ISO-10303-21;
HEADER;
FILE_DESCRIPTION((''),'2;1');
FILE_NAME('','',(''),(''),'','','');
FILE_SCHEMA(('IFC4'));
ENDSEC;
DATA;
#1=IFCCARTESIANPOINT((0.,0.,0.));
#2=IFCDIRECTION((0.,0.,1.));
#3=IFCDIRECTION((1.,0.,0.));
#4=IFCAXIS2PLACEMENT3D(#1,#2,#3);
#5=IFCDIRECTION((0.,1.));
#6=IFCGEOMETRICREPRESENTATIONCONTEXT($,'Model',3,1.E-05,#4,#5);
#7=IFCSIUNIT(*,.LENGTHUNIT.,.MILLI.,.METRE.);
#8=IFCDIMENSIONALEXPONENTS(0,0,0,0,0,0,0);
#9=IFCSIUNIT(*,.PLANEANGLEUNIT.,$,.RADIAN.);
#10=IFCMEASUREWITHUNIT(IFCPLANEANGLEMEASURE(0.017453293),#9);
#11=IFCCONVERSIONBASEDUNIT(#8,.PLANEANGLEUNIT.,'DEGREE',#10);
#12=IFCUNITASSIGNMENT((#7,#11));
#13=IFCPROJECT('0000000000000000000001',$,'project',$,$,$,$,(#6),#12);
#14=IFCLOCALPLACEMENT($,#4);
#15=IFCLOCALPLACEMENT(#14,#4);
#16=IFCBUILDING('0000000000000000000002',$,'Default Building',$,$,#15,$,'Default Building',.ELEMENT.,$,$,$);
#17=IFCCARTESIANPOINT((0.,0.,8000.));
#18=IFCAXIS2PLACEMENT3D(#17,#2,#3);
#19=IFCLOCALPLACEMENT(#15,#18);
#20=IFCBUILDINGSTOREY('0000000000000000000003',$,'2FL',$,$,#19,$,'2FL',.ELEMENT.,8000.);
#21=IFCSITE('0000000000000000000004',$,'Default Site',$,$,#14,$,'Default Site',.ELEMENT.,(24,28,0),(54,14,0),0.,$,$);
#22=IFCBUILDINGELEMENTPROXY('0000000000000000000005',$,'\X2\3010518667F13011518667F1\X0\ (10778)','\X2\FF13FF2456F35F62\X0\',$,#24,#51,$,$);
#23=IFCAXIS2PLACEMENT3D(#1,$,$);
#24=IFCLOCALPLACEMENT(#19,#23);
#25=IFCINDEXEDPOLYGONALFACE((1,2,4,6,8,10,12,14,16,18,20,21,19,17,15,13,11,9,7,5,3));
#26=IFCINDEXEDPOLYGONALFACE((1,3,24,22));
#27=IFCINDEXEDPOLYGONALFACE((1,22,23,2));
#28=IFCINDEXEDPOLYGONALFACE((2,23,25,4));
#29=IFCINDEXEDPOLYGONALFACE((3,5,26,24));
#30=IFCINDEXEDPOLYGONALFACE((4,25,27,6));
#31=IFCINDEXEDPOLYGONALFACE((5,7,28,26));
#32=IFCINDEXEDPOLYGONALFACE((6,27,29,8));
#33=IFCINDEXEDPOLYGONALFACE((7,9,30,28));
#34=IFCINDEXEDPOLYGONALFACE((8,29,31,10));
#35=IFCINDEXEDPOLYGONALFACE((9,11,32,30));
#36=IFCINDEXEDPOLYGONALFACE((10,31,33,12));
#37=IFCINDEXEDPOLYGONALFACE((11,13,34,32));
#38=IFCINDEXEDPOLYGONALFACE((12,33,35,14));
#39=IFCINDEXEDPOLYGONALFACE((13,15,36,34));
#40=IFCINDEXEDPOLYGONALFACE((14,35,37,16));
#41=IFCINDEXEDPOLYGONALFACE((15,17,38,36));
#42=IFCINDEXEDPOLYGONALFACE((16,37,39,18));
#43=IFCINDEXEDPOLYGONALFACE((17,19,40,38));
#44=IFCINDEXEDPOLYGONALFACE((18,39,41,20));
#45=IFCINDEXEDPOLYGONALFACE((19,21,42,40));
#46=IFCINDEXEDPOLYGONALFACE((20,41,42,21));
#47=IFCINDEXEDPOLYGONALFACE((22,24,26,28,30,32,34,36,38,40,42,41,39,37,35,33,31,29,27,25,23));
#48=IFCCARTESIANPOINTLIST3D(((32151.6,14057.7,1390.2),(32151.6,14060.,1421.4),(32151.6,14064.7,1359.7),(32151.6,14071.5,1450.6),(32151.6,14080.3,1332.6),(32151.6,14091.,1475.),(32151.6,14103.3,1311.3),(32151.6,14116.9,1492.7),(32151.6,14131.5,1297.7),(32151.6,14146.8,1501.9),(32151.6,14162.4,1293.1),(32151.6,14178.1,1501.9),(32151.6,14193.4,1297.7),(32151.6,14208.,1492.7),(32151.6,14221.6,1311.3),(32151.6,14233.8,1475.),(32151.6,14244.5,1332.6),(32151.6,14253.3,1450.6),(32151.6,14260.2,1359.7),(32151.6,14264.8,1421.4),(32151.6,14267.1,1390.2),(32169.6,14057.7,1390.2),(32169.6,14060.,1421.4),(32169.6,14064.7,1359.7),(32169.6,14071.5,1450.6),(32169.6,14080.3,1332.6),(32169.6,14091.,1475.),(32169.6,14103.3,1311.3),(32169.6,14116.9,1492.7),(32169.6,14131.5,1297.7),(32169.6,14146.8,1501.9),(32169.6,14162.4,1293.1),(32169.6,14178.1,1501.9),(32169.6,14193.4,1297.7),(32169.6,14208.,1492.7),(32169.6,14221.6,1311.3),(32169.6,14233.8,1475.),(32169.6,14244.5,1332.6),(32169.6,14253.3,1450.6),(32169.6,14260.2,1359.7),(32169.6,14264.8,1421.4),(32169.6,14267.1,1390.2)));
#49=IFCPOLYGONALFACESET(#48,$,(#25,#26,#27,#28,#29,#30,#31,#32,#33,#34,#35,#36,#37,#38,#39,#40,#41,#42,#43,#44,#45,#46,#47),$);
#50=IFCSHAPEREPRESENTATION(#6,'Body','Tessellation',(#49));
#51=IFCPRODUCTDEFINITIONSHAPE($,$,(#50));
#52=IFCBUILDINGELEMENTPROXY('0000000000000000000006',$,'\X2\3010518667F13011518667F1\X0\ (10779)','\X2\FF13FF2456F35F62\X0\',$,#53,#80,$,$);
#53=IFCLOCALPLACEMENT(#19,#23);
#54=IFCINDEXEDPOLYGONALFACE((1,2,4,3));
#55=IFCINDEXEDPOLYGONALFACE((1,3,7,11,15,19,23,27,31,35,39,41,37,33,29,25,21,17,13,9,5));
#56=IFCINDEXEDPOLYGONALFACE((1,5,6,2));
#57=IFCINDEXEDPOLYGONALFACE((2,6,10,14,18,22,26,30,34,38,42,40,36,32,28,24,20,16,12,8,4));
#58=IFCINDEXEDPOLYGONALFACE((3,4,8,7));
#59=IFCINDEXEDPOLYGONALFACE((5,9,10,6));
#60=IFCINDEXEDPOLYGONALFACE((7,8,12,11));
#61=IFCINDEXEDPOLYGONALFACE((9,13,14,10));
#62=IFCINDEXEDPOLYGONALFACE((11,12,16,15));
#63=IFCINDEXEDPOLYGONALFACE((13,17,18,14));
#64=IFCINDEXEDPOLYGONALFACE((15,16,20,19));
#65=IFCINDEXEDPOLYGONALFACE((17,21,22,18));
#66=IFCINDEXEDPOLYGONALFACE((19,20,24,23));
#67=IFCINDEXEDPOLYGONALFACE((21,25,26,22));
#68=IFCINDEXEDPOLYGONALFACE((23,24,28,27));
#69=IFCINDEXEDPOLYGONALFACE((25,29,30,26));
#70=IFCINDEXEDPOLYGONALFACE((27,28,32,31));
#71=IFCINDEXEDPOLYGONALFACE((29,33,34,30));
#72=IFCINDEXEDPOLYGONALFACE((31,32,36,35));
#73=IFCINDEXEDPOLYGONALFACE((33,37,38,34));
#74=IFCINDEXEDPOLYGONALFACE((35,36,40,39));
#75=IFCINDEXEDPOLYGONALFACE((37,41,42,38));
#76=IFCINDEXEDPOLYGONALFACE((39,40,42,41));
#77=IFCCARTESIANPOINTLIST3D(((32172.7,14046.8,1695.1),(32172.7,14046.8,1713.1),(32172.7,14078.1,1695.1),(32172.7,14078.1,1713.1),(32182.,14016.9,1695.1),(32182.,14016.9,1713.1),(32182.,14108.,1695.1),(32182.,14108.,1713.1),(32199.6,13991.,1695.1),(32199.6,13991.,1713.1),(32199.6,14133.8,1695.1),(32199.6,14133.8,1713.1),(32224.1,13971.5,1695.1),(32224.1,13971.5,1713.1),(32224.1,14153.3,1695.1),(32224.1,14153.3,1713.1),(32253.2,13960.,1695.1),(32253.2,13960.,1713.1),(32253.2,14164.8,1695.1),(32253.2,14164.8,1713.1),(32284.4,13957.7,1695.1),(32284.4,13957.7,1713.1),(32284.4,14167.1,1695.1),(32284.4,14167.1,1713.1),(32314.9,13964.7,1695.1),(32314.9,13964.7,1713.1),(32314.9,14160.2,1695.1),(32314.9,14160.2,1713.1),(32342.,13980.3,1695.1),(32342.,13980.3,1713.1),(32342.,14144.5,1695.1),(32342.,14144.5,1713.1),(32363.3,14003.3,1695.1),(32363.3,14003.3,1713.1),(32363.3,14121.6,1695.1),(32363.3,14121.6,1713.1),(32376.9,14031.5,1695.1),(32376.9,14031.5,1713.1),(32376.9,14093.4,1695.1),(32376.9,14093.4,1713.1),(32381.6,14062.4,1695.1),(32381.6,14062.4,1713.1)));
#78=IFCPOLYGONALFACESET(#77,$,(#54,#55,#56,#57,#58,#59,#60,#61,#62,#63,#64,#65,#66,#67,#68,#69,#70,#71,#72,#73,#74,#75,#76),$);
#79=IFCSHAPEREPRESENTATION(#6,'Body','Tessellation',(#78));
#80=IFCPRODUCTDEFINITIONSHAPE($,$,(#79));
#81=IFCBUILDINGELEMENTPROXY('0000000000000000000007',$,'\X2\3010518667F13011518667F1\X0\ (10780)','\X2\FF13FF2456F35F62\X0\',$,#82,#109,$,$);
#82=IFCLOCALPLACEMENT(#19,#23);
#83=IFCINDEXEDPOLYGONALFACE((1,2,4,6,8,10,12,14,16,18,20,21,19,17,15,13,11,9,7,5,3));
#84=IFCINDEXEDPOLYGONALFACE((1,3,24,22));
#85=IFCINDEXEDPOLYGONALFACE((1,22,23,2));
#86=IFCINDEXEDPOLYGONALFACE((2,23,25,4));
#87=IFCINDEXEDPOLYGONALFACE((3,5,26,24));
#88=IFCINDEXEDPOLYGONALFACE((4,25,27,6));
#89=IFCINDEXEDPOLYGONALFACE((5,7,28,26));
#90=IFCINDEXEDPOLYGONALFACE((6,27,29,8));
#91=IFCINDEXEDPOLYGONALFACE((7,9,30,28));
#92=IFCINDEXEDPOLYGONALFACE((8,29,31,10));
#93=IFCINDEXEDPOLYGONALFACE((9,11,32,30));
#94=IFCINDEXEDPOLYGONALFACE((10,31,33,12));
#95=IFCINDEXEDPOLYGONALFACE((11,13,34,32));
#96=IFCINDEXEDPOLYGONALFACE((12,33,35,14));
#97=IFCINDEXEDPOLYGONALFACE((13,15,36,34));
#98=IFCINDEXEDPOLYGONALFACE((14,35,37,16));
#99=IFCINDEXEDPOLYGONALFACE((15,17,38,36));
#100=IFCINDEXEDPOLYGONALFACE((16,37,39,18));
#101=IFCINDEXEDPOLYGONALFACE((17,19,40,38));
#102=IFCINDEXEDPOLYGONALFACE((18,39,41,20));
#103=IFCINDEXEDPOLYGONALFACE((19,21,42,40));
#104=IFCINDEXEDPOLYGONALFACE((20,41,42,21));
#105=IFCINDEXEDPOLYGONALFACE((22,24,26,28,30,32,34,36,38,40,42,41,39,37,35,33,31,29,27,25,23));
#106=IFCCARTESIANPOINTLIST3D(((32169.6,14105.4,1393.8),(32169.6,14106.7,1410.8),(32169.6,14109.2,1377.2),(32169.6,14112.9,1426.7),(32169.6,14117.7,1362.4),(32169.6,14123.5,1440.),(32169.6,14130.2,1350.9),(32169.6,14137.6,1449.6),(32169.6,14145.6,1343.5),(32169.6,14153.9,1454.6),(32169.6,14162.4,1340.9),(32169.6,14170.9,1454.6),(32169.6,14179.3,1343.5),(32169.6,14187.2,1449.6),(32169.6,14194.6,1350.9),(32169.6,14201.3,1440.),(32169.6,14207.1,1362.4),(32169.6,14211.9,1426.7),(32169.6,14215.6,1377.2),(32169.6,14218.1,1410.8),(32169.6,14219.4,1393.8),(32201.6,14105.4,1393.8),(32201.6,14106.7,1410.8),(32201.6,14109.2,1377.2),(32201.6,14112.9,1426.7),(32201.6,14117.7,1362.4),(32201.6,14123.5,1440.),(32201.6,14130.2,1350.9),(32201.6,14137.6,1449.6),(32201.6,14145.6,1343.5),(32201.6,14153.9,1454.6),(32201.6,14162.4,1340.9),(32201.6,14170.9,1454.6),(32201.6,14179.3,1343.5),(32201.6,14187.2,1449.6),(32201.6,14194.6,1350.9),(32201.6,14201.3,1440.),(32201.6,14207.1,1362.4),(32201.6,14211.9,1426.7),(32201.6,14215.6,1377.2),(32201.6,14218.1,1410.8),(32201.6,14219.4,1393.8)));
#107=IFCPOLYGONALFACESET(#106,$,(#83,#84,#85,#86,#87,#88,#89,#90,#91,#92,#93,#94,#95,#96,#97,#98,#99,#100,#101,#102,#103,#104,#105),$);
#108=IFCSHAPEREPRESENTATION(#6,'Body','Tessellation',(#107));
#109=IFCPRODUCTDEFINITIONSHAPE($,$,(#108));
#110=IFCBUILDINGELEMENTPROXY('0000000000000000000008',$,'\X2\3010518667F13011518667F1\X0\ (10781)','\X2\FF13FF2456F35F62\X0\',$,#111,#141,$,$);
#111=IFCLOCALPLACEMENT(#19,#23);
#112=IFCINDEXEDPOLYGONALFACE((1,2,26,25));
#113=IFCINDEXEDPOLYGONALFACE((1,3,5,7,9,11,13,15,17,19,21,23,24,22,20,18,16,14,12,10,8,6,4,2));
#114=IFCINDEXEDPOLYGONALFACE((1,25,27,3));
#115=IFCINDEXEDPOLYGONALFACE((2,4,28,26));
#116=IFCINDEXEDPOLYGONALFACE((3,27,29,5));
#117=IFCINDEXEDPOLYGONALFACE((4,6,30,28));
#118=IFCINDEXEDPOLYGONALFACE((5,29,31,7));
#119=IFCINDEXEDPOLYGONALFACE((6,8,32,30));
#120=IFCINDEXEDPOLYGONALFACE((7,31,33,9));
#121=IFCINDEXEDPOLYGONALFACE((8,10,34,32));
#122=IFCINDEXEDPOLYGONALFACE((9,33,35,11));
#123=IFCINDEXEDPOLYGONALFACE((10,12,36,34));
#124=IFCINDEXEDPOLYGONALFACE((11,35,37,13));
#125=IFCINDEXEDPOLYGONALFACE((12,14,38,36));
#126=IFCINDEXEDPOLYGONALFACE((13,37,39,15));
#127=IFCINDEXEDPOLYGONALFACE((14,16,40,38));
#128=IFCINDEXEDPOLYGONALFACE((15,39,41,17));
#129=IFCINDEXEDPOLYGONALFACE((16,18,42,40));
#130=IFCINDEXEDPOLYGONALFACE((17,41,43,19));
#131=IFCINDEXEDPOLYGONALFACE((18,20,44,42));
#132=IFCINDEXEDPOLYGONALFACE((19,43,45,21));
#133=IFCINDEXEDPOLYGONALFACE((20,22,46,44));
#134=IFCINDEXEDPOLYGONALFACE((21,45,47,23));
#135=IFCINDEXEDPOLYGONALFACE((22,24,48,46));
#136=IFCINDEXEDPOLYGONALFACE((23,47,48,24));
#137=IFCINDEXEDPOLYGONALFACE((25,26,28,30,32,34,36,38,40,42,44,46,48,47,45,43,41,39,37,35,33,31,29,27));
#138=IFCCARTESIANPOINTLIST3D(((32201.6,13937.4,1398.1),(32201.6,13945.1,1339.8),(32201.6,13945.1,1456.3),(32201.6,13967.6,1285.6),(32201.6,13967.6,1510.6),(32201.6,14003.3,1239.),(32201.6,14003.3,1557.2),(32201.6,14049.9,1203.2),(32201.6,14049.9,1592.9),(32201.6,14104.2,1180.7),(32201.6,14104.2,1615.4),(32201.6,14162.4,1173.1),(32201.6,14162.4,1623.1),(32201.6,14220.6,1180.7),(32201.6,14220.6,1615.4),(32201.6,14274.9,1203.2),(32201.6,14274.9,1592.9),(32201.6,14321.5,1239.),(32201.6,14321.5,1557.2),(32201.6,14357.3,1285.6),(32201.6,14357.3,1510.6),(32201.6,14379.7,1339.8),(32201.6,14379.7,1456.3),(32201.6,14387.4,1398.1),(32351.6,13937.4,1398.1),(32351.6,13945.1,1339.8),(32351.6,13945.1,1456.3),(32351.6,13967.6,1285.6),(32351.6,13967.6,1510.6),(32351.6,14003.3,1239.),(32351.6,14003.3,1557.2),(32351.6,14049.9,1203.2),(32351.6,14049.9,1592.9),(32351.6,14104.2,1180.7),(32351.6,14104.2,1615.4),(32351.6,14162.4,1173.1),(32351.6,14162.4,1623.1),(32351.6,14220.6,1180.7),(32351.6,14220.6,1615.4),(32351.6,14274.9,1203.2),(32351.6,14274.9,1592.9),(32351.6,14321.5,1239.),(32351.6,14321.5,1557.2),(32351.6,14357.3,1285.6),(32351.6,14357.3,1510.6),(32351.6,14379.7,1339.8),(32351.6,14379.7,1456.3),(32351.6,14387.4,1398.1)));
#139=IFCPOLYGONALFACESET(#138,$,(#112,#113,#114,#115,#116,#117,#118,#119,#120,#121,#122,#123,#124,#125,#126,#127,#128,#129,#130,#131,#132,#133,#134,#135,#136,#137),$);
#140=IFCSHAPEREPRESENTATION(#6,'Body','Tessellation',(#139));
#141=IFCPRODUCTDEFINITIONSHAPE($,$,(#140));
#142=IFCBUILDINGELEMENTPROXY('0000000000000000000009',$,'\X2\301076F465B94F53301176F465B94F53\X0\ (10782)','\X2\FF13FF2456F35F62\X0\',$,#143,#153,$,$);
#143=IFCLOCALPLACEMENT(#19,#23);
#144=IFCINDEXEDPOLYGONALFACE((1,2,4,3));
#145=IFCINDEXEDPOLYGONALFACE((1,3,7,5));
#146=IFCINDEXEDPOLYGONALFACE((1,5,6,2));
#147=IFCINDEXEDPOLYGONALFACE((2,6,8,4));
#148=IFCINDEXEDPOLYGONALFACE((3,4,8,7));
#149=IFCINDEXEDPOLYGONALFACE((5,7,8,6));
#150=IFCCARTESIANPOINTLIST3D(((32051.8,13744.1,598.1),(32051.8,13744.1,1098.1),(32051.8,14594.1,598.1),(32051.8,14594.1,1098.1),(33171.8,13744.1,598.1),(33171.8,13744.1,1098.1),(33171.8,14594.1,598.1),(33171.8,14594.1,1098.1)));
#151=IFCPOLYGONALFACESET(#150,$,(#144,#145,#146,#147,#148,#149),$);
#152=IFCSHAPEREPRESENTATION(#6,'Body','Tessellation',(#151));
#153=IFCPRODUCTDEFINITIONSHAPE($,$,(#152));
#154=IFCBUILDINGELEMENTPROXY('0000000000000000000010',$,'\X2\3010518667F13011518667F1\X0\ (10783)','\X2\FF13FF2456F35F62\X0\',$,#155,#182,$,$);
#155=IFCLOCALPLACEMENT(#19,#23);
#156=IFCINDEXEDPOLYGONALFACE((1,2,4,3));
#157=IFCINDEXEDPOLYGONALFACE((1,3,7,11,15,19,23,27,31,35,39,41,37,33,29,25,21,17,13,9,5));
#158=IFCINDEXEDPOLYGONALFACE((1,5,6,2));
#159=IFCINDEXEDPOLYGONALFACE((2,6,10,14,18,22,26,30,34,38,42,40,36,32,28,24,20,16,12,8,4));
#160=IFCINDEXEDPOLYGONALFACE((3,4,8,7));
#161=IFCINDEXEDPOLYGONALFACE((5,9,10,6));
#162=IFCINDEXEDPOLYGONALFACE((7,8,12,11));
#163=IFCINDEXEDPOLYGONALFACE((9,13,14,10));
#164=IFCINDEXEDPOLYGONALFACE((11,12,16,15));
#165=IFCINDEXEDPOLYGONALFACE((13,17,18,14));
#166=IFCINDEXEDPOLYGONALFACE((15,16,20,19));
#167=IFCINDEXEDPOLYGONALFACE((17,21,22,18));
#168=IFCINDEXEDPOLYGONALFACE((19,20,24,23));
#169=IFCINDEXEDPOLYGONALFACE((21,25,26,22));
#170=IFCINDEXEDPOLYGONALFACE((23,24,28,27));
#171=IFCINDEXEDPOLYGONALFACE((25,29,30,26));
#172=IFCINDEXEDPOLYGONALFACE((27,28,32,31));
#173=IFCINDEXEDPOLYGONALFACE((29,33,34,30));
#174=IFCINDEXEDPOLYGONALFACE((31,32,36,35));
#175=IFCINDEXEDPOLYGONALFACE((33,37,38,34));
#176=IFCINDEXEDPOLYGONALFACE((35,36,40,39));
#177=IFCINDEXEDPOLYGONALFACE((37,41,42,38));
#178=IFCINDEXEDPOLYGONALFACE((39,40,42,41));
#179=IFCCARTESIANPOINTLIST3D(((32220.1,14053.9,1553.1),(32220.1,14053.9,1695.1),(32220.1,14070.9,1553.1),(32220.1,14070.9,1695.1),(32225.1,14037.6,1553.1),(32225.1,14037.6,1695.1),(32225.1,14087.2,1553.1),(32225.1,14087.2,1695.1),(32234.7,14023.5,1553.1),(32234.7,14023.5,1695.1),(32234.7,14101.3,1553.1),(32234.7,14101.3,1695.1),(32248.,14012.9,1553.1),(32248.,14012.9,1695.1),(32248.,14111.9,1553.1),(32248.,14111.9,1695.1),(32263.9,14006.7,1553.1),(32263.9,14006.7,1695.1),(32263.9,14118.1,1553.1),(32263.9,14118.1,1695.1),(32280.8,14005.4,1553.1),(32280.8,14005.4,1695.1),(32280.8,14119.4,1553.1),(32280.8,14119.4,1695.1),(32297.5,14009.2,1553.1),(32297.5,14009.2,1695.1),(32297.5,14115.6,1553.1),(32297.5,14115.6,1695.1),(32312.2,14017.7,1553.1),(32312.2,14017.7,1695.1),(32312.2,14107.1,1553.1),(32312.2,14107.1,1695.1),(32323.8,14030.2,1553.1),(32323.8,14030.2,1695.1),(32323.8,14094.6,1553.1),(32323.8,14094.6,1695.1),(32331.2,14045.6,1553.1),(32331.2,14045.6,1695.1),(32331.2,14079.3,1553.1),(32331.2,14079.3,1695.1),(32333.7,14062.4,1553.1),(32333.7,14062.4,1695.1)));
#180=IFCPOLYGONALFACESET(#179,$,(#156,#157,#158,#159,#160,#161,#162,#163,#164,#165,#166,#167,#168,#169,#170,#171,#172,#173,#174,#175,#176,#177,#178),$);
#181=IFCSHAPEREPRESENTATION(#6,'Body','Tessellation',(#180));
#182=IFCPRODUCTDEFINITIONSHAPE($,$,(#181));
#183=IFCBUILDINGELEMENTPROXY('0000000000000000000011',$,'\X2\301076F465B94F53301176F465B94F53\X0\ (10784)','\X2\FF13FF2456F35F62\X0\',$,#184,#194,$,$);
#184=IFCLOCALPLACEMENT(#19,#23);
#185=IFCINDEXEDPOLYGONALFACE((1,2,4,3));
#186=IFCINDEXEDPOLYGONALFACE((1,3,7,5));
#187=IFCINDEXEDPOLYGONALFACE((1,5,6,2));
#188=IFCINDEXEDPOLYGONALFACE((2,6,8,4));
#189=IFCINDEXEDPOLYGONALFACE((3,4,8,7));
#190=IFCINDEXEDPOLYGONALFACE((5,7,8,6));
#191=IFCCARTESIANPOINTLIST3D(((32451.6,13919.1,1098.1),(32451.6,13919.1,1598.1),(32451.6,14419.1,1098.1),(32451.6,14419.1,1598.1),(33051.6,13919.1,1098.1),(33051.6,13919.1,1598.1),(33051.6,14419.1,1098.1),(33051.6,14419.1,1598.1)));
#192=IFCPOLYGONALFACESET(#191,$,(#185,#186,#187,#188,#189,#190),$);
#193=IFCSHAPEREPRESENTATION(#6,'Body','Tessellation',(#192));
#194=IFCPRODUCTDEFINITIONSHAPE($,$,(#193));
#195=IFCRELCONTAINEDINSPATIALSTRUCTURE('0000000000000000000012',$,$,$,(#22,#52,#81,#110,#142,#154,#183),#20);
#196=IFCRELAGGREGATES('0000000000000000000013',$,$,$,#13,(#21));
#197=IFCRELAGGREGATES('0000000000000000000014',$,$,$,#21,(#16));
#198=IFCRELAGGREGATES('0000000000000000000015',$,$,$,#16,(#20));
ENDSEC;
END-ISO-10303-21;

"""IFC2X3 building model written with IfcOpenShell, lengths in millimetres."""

from ifc_helpers import new_model, entity, si_unit, converted_unit, direction, frame, origin_with_axes, origin_2d_with_axis, place, context, project, spatial, rectangle, circle, extrude, source, transform, mapped, element, save


model = new_model("IFC2X3")

# Units and contexts
model_context = context("Model", 3, precision=1e-05, world=origin_with_axes(), true_north=direction((0.0, 1.0)))
ifc_project = project(units=[si_unit("LENGTHUNIT", "METRE", prefix="MILLI"), converted_unit("PLANEANGLEUNIT", "DEGREE", entity("IfcPlaneAngleMeasure", 0.017453293), si_unit("PLANEANGLEUNIT", "RADIAN"), dimensions=[0, 0, 0, 0, 0, 0, 0])], contexts=[model_context])

# Site, building, storey
site_placement = place(None, origin_with_axes())
site = spatial("IfcSite", under=ifc_project, at=site_placement, Name="Default Site", LongName="Default Site", CompositionType="ELEMENT", RefLatitude=(24, 28, 0), RefLongitude=(54, 14, 0), RefElevation=0.0)
building_placement = place(site_placement, origin_with_axes())
building = spatial("IfcBuilding", under=site, at=building_placement, Name="Default Building", LongName="Default Building", CompositionType="ELEMENT")
storey_placement = place(building_placement, frame((0.0, 0.0, 8000.0), z_axis=(0.0, 0.0, 1.0), x_axis=(1.0, 0.0, 0.0)))
storey = spatial("IfcBuildingStorey", under=building, at=storey_placement, Name="2FL", LongName="2FL", CompositionType="ELEMENT", Elevation=8000.0)

# Building element proxies
shared_shape_1 = source(origin_with_axes(), model_context, "Body", "SweptSolid", [
    extrude(circle(Radius=105.0, at=origin_2d_with_axis()), frame((0.0, 0.0, 0.0), z_axis=(0.0, 0.0, 1.0), x_axis=(1.0, 0.0, 0.0)), (0.0, 0.0, 1.0), 18.0),
])
proxy_1_placement = place(storey_placement, frame((32151.6, 14162.4, 1398.1), z_axis=(1.0, 0.0, 0.0), x_axis=(0.0, 0.0, -1.0)))
element("IfcBuildingElementProxy", 1, at=proxy_1_placement, inside=storey, Name="【円柱】円柱 (10778)", Description="３Ｄ図形", context=model_context, shape_type="MappedRepresentation", body=[
    mapped(shared_shape_1, transform((0.0, 0.0, 0.0))),
])
shared_shape_2 = source(origin_with_axes(), model_context, "Body", "SweptSolid", [
    extrude(circle(Radius=105.0, at=origin_2d_with_axis()), frame((0.0, 0.0, 0.0), z_axis=(0.0, 0.0, 1.0), x_axis=(1.0, 0.0, 0.0)), (0.0, 0.0, 1.0), 18.0),
])
proxy_2_placement = place(storey_placement, frame((32276.6, 14062.4, 1713.1), z_axis=(0.0, 0.0, -1.0), x_axis=(1.0, 0.0, 0.0)))
element("IfcBuildingElementProxy", 2, at=proxy_2_placement, inside=storey, Name="【円柱】円柱 (10779)", Description="３Ｄ図形", context=model_context, shape_type="MappedRepresentation", body=[
    mapped(shared_shape_2, transform((0.0, 0.0, 0.0))),
])
shared_shape_3 = source(origin_with_axes(), model_context, "Body", "SweptSolid", [
    extrude(circle(Radius=57.1, at=origin_2d_with_axis()), frame((0.0, 0.0, 0.0), z_axis=(0.0, 0.0, 1.0), x_axis=(1.0, 0.0, 0.0)), (0.0, 0.0, 1.0), 32.0),
])
proxy_3_placement = place(storey_placement, frame((32201.6, 14162.4, 1398.1), z_axis=(-1.0, 0.0, 0.0), x_axis=(0.0, 0.0, -1.0)))
element("IfcBuildingElementProxy", 3, at=proxy_3_placement, inside=storey, Name="【円柱】円柱 (10780)", Description="３Ｄ図形", context=model_context, shape_type="MappedRepresentation", body=[
    mapped(shared_shape_3, transform((0.0, 0.0, 0.0))),
])
shared_shape_4 = source(origin_with_axes(), model_context, "Body", "SweptSolid", [
    extrude(circle(Radius=225.0, at=origin_2d_with_axis()), frame((0.0, 0.0, 0.0), z_axis=(0.0, 0.0, 1.0), x_axis=(1.0, 0.0, 0.0)), (0.0, 0.0, 1.0), 150.0),
])
proxy_4_placement = place(storey_placement, frame((32351.6, 14162.4, 1398.1), z_axis=(-1.0, 0.0, 0.0), x_axis=(0.0, -1.0, 0.0)))
element("IfcBuildingElementProxy", 4, at=proxy_4_placement, inside=storey, Name="【円柱】円柱 (10781)", Description="３Ｄ図形", context=model_context, shape_type="MappedRepresentation", body=[
    mapped(shared_shape_4, transform((0.0, 0.0, 0.0))),
])
shared_shape_5 = source(origin_with_axes(), model_context, "Body", "SweptSolid", [
    extrude(rectangle(XDim=1120.0, YDim=850.0, at=origin_2d_with_axis()), origin_with_axes(), (0.0, 0.0, 1.0), 500.0),
])
proxy_5_placement = place(storey_placement, frame((32611.8, 14169.1, 598.1), z_axis=(0.0, 0.0, 1.0), x_axis=(1.0, 0.0, 0.0)))
element("IfcBuildingElementProxy", 5, at=proxy_5_placement, inside=storey, Name="【直方体】直方体 (10782)", Description="３Ｄ図形", context=model_context, shape_type="MappedRepresentation", body=[
    mapped(shared_shape_5, transform((0.0, 0.0, 0.0))),
])
shared_shape_6 = source(origin_with_axes(), model_context, "Body", "SweptSolid", [
    extrude(circle(Radius=57.1, at=origin_2d_with_axis()), origin_with_axes(), (0.0, 0.0, 1.0), 142.0),
])
proxy_6_placement = place(storey_placement, frame((32276.6, 14062.4, 1553.1), z_axis=(0.0, 0.0, 1.0), x_axis=(1.0, 0.0, 0.0)))
element("IfcBuildingElementProxy", 6, at=proxy_6_placement, inside=storey, Name="【円柱】円柱 (10783)", Description="３Ｄ図形", context=model_context, shape_type="MappedRepresentation", body=[
    mapped(shared_shape_6, transform((0.0, 0.0, 0.0))),
])
shared_shape_7 = source(origin_with_axes(), model_context, "Body", "SweptSolid", [
    extrude(rectangle(XDim=600.0, YDim=500.0, at=origin_2d_with_axis()), origin_with_axes(), (0.0, 0.0, 1.0), 500.0),
])
proxy_7_placement = place(storey_placement, frame((32751.6, 14169.1, 1098.1), z_axis=(0.0, 0.0, 1.0), x_axis=(1.0, 0.0, 0.0)))
element("IfcBuildingElementProxy", 7, at=proxy_7_placement, inside=storey, Name="【直方体】直方体 (10784)", Description="３Ｄ図形", context=model_context, shape_type="MappedRepresentation", body=[
    mapped(shared_shape_7, transform((0.0, 0.0, 0.0))),
])

save(model, "model.ifc")
